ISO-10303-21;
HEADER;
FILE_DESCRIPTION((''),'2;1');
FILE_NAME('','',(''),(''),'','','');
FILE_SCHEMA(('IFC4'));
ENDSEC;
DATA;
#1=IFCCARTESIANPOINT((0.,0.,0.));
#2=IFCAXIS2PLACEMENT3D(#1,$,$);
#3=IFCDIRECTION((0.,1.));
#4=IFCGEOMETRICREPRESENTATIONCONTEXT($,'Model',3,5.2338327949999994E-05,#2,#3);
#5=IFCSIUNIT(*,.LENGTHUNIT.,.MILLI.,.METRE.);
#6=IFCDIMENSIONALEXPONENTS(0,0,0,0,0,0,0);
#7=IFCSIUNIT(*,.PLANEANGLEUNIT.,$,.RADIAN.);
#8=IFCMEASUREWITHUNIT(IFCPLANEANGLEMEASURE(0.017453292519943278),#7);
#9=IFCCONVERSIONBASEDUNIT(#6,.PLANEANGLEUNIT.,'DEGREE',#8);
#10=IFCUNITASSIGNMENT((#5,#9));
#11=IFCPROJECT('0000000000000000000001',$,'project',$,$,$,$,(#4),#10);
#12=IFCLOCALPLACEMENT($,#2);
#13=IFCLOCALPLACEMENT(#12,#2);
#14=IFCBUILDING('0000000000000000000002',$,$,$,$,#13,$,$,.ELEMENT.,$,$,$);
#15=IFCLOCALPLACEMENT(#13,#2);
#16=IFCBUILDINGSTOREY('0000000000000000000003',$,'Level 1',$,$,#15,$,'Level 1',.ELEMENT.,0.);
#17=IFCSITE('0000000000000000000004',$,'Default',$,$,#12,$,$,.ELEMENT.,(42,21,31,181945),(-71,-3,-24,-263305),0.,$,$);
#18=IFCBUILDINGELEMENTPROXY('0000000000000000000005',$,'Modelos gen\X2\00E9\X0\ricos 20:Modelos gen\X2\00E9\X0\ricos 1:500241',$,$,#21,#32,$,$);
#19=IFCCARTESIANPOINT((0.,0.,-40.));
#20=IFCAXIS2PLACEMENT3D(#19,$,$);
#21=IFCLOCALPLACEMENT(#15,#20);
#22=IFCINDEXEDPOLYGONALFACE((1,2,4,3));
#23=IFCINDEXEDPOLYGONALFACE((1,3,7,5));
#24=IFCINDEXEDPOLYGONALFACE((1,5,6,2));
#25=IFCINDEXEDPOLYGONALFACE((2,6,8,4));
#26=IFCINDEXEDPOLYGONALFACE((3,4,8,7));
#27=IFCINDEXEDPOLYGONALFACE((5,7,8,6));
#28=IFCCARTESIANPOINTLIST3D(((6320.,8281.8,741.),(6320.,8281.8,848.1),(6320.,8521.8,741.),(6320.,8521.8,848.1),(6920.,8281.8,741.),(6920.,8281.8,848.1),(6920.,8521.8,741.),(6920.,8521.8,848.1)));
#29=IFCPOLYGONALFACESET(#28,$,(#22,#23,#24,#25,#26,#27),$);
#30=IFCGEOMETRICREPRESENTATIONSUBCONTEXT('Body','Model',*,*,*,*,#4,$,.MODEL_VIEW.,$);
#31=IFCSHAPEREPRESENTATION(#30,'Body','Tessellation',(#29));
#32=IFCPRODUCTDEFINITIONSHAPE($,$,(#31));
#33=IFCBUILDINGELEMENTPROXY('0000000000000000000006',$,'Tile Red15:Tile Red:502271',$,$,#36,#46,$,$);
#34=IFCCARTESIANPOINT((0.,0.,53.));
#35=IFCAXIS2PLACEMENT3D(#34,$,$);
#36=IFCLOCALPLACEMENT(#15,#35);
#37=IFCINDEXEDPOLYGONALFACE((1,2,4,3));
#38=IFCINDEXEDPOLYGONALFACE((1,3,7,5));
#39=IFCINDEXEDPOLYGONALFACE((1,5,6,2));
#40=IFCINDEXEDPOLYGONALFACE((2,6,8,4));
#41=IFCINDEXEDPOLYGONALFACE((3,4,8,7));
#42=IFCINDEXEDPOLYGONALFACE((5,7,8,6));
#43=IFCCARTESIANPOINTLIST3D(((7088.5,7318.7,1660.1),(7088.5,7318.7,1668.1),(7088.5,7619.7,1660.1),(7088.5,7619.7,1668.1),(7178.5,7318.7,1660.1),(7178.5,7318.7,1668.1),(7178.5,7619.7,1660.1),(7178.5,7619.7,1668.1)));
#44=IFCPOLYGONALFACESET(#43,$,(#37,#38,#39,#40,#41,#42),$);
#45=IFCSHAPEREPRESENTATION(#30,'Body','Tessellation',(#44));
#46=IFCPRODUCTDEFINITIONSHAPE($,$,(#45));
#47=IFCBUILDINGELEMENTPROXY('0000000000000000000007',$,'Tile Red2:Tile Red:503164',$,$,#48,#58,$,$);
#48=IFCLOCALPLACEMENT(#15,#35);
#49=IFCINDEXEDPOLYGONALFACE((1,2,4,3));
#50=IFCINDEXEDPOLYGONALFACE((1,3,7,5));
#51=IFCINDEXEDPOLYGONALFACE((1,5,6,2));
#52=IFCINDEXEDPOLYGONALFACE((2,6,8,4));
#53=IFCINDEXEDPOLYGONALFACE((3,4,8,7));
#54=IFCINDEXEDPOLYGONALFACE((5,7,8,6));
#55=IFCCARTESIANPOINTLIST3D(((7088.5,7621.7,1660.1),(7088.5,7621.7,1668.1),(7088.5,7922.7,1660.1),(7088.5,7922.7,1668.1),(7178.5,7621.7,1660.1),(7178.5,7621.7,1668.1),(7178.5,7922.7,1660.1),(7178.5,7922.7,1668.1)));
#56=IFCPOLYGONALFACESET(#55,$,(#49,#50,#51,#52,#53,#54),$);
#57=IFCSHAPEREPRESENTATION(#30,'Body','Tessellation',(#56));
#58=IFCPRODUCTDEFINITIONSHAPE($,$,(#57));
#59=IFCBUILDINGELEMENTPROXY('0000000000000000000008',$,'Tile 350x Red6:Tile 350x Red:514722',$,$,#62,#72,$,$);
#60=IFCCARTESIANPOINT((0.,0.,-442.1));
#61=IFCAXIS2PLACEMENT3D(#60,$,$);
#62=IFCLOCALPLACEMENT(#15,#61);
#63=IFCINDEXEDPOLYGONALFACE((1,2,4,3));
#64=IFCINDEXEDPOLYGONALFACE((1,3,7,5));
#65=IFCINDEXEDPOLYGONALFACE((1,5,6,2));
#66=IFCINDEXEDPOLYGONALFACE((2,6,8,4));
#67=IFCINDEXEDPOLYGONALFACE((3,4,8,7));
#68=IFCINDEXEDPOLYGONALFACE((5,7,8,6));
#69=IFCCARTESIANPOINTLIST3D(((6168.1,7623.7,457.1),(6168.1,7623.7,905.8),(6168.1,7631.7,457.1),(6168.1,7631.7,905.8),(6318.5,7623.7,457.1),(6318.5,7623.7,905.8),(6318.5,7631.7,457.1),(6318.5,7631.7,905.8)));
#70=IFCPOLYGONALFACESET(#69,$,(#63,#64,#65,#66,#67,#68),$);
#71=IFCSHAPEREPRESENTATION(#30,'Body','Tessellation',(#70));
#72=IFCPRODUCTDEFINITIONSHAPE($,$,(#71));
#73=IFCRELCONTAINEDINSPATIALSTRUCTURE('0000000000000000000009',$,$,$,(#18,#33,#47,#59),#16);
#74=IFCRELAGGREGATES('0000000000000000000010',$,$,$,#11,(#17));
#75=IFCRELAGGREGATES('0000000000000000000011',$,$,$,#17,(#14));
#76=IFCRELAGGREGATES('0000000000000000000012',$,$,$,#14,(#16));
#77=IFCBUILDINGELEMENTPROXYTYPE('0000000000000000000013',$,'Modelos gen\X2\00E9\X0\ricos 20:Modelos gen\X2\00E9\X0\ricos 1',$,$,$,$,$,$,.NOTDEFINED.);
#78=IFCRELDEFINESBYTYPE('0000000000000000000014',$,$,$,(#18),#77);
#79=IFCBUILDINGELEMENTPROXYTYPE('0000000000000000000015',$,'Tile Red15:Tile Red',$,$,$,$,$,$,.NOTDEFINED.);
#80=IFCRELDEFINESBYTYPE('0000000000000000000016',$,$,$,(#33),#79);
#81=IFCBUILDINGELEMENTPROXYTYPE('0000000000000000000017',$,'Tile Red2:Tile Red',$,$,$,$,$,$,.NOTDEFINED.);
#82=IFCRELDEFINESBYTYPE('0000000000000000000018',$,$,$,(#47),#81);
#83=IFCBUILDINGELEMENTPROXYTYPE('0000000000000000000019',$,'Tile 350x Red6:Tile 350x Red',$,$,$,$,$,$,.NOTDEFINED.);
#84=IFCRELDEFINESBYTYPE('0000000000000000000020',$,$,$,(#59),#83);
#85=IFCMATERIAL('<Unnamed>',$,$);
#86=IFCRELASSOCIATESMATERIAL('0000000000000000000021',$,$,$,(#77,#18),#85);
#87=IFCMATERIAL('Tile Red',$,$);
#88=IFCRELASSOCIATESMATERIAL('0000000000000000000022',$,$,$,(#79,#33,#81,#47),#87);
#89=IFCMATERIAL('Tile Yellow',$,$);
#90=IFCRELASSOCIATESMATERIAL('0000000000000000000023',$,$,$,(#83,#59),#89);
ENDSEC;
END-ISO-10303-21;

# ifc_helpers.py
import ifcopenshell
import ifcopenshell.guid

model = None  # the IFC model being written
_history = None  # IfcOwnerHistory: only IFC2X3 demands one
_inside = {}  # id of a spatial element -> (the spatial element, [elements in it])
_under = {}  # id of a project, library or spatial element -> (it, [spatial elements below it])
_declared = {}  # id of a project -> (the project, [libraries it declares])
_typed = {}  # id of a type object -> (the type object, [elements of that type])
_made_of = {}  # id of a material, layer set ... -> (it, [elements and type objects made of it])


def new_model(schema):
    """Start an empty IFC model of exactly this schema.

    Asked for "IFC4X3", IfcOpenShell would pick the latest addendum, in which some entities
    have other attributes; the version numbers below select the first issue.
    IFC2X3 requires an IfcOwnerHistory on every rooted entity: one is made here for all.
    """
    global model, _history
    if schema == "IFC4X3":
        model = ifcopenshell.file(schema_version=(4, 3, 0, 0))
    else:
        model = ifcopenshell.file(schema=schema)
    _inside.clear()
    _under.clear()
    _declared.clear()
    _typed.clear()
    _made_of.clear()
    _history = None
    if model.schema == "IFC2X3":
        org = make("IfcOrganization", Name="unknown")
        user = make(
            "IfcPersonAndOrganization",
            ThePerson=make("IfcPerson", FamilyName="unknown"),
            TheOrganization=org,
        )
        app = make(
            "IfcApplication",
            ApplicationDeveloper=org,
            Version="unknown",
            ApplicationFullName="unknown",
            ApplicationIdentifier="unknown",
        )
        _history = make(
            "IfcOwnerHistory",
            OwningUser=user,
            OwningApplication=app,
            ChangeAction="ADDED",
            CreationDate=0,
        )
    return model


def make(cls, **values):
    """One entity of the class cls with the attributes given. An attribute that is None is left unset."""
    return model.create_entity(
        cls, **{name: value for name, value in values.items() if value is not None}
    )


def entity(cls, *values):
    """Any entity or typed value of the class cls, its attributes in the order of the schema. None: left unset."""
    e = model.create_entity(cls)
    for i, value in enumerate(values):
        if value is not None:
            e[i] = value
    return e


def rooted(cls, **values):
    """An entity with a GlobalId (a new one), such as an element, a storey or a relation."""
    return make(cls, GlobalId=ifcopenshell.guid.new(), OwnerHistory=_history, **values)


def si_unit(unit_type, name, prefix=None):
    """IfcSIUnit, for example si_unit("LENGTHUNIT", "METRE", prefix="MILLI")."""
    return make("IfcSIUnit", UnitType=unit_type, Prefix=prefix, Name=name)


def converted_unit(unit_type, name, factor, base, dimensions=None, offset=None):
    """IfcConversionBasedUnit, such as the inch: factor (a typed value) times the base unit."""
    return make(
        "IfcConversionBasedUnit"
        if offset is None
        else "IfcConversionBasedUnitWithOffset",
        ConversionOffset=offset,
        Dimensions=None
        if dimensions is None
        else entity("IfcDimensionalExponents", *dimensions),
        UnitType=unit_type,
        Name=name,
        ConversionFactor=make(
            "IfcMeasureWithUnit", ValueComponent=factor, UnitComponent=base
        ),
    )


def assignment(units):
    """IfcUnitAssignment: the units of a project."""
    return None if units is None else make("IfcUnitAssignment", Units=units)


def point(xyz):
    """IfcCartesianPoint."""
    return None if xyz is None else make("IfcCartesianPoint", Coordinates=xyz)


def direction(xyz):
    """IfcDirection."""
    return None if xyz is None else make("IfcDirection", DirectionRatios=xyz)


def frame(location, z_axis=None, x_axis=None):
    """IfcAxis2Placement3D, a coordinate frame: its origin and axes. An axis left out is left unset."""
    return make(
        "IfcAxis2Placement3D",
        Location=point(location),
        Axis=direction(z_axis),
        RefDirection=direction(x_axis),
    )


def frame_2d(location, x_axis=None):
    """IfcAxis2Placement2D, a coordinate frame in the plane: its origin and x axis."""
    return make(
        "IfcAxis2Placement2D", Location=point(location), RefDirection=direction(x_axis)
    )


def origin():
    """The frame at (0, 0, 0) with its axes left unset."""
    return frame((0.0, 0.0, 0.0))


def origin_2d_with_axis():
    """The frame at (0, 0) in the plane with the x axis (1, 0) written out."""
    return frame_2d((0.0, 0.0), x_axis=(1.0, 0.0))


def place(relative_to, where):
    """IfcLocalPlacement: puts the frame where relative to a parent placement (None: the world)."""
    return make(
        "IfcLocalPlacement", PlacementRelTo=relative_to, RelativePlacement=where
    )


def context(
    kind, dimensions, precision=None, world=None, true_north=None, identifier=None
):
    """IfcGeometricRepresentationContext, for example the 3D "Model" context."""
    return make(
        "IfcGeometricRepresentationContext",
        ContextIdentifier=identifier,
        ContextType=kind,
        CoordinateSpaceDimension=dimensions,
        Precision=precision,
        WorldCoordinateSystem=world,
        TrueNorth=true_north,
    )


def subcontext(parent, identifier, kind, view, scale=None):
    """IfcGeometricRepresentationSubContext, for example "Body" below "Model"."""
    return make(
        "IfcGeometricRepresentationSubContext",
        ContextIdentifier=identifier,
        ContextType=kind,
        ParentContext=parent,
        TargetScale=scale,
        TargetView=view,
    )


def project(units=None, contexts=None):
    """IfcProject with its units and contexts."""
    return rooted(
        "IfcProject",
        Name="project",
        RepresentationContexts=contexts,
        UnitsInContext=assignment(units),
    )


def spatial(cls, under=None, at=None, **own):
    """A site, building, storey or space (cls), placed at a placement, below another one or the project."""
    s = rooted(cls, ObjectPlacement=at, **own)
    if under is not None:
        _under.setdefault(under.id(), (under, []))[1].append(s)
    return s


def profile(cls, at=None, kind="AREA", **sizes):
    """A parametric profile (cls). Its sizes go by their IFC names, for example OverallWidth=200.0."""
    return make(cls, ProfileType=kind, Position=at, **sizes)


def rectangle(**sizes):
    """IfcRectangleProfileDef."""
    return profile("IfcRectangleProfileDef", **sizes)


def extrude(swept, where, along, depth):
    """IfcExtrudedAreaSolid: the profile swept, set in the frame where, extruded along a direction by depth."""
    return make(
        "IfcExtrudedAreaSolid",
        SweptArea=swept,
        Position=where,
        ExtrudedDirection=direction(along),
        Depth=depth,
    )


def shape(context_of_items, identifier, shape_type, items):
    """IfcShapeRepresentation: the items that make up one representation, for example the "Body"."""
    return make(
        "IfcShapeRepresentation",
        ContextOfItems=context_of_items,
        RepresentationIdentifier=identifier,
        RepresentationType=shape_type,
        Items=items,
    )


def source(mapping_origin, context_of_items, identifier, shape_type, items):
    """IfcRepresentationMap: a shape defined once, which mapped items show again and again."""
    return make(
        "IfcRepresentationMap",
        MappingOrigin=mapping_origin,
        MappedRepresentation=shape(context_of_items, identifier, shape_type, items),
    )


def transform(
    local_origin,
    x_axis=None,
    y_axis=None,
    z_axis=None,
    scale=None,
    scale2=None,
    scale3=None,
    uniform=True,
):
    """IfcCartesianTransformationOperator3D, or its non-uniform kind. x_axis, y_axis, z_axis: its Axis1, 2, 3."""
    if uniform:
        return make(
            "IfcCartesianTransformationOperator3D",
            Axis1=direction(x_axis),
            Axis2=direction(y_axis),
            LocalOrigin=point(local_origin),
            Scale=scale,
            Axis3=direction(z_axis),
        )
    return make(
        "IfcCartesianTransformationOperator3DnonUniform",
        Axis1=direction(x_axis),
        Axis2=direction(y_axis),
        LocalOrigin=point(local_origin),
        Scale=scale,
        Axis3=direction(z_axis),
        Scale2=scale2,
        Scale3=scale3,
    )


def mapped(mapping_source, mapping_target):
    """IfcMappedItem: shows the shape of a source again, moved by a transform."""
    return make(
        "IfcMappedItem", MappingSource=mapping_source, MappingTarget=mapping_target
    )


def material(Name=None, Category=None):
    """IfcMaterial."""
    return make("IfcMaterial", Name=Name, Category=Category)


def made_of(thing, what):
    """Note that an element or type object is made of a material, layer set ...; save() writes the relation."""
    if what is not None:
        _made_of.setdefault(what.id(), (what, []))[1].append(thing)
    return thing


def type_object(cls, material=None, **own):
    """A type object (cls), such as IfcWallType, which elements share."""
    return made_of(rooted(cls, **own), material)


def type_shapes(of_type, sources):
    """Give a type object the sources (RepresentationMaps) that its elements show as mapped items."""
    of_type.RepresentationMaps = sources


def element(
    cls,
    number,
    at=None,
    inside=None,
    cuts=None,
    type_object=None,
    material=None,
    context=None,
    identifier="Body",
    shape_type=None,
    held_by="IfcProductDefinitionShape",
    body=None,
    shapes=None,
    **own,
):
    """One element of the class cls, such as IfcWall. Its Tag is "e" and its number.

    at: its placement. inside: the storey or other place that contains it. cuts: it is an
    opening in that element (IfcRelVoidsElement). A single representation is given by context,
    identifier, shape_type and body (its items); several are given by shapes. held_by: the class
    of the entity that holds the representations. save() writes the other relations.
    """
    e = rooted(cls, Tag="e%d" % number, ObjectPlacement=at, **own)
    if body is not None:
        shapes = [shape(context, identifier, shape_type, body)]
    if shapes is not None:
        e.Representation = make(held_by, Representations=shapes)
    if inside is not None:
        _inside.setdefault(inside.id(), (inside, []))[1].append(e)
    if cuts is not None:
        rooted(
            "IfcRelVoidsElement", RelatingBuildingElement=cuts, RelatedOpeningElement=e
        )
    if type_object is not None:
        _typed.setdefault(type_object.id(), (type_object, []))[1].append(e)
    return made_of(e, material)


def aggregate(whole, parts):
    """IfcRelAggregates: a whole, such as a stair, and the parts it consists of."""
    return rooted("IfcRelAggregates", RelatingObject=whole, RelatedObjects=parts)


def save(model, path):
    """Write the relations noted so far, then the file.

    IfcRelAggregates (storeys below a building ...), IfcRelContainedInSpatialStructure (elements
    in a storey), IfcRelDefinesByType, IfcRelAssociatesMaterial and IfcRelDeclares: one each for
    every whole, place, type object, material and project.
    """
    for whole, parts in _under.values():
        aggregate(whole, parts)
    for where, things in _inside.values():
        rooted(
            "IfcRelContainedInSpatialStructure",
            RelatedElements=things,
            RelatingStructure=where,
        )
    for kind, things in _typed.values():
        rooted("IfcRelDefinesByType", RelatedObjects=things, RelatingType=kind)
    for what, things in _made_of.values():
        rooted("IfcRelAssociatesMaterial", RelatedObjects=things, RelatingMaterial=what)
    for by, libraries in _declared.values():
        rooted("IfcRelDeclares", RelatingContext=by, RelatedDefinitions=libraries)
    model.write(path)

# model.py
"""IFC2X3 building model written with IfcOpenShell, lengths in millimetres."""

from ifc_helpers import new_model, entity, si_unit, converted_unit, direction, frame, frame_2d, origin, origin_2d_with_axis, place, context, subcontext, project, spatial, rectangle, extrude, source, transform, mapped, material, type_object, type_shapes, element, save


model = new_model("IFC2X3")

# Units and contexts
model_context = context("Model", 3, precision=5.2338327949999994e-05, world=origin(), true_north=direction((0.0, 1.0)))
body_context = subcontext(model_context, "Body", "Model", "MODEL_VIEW")
ifc_project = project(units=[si_unit("LENGTHUNIT", "METRE", prefix="MILLI"), converted_unit("PLANEANGLEUNIT", "DEGREE", entity("IfcPlaneAngleMeasure", 0.017453292519943278), si_unit("PLANEANGLEUNIT", "RADIAN"), dimensions=[0, 0, 0, 0, 0, 0, 0])], contexts=[model_context])

# Site, building, storey
site_placement = place(None, origin())
site = spatial("IfcSite", under=ifc_project, at=site_placement, Name="Default", CompositionType="ELEMENT", RefLatitude=(42, 21, 31, 181945), RefLongitude=(-71, -3, -24, -263305), RefElevation=0.0)
building_placement = place(site_placement, origin())
building = spatial("IfcBuilding", under=site, at=building_placement, CompositionType="ELEMENT")
storey_placement = place(building_placement, origin())
storey = spatial("IfcBuildingStorey", under=building, at=storey_placement, Name="Level 1", LongName="Level 1", CompositionType="ELEMENT", Elevation=0.0)

# Building element proxies
ifc_material_1 = material(Name="Tile Red")
ifc_material_2 = material(Name="<Unnamed>")
building_element_proxy_type_1 = type_object("IfcBuildingElementProxyType", Name="Modelos genéricos 20:Modelos genéricos 1", PredefinedType="NOTDEFINED", material=ifc_material_2)
shared_shape_1 = source(origin(), body_context, "Body", "SweptSolid", [
    extrude(rectangle(XDim=600.0, YDim=240.0, at=origin_2d_with_axis()), frame((6620.0, 8401.8, 741.0), z_axis=(0.0, 0.0, 1.0), x_axis=(-1.0, 0.0, 0.0)), (0.0, 0.0, 1.0), 107.1),
])
type_shapes(building_element_proxy_type_1, [shared_shape_1])
proxy_1_placement = place(storey_placement, frame((0.0, 0.0, -40.0)))
element("IfcBuildingElementProxy", 1, at=proxy_1_placement, inside=storey, type_object=building_element_proxy_type_1, material=ifc_material_2, Name="Modelos genéricos 20:Modelos genéricos 1:500241", context=body_context, shape_type="MappedRepresentation", body=[
    mapped(shared_shape_1, transform((0.0, 0.0, 0.0), scale=1.0)),
])
building_element_proxy_type_2 = type_object("IfcBuildingElementProxyType", Name="Tile Red15:Tile Red", PredefinedType="NOTDEFINED", material=ifc_material_1)
shared_shape_2 = source(origin(), body_context, "Body", "SweptSolid", [
    extrude(rectangle(XDim=90.0, YDim=301.0, at=frame_2d((0.0, 0.0), x_axis=(1.0, 0.0))), frame((7133.5, 7469.2, 1660.1)), (0.0, 0.0, 1.0), 8.0),
])
type_shapes(building_element_proxy_type_2, [shared_shape_2])
proxy_2_placement = place(storey_placement, frame((0.0, 0.0, 53.0)))
element("IfcBuildingElementProxy", 2, at=proxy_2_placement, inside=storey, type_object=building_element_proxy_type_2, material=ifc_material_1, Name="Tile Red15:Tile Red:502271", context=body_context, shape_type="MappedRepresentation", body=[
    mapped(shared_shape_2, transform((0.0, 0.0, 0.0), scale=1.0)),
])
building_element_proxy_type_3 = type_object("IfcBuildingElementProxyType", Name="Tile Red2:Tile Red", PredefinedType="NOTDEFINED", material=ifc_material_1)
shared_shape_3 = source(origin(), body_context, "Body", "SweptSolid", [
    extrude(rectangle(XDim=301.0, YDim=90.0, at=frame_2d((0.0, 0.0), x_axis=(1.0, 0.0))), frame((7133.5, 7772.2, 1660.1), z_axis=(0.0, 0.0, 1.0), x_axis=(0.0, -1.0, 0.0)), (0.0, 0.0, 1.0), 8.0),
])
type_shapes(building_element_proxy_type_3, [shared_shape_3])
proxy_3_placement = place(storey_placement, frame((0.0, 0.0, 53.0)))
element("IfcBuildingElementProxy", 3, at=proxy_3_placement, inside=storey, type_object=building_element_proxy_type_3, material=ifc_material_1, Name="Tile Red2:Tile Red:503164", context=body_context, shape_type="MappedRepresentation", body=[
    mapped(shared_shape_3, transform((0.0, 0.0, 0.0), scale=1.0)),
])
ifc_material_3 = material(Name="Tile Yellow")
building_element_proxy_type_4 = type_object("IfcBuildingElementProxyType", Name="Tile 350x Red6:Tile 350x Red", PredefinedType="NOTDEFINED", material=ifc_material_3)
shared_shape_4 = source(origin(), body_context, "Body", "SweptSolid", [
    extrude(rectangle(XDim=8.0, YDim=150.5, at=frame_2d((0.0, 0.0), x_axis=(1.0, 0.0))), frame((6243.3, 7627.7, 457.1), z_axis=(0.0, 0.0, 1.0), x_axis=(0.0, -1.0, 0.0)), (0.0, 0.0, 1.0), 448.8),
])
type_shapes(building_element_proxy_type_4, [shared_shape_4])
proxy_4_placement = place(storey_placement, frame((0.0, 0.0, -442.1)))
element("IfcBuildingElementProxy", 4, at=proxy_4_placement, inside=storey, type_object=building_element_proxy_type_4, material=ifc_material_3, Name="Tile 350x Red6:Tile 350x Red:514722", context=body_context, shape_type="MappedRepresentation", body=[
    mapped(shared_shape_4, transform((0.0, 0.0, 0.0), scale=1.0)),
])

save(model, "model.ifc")
